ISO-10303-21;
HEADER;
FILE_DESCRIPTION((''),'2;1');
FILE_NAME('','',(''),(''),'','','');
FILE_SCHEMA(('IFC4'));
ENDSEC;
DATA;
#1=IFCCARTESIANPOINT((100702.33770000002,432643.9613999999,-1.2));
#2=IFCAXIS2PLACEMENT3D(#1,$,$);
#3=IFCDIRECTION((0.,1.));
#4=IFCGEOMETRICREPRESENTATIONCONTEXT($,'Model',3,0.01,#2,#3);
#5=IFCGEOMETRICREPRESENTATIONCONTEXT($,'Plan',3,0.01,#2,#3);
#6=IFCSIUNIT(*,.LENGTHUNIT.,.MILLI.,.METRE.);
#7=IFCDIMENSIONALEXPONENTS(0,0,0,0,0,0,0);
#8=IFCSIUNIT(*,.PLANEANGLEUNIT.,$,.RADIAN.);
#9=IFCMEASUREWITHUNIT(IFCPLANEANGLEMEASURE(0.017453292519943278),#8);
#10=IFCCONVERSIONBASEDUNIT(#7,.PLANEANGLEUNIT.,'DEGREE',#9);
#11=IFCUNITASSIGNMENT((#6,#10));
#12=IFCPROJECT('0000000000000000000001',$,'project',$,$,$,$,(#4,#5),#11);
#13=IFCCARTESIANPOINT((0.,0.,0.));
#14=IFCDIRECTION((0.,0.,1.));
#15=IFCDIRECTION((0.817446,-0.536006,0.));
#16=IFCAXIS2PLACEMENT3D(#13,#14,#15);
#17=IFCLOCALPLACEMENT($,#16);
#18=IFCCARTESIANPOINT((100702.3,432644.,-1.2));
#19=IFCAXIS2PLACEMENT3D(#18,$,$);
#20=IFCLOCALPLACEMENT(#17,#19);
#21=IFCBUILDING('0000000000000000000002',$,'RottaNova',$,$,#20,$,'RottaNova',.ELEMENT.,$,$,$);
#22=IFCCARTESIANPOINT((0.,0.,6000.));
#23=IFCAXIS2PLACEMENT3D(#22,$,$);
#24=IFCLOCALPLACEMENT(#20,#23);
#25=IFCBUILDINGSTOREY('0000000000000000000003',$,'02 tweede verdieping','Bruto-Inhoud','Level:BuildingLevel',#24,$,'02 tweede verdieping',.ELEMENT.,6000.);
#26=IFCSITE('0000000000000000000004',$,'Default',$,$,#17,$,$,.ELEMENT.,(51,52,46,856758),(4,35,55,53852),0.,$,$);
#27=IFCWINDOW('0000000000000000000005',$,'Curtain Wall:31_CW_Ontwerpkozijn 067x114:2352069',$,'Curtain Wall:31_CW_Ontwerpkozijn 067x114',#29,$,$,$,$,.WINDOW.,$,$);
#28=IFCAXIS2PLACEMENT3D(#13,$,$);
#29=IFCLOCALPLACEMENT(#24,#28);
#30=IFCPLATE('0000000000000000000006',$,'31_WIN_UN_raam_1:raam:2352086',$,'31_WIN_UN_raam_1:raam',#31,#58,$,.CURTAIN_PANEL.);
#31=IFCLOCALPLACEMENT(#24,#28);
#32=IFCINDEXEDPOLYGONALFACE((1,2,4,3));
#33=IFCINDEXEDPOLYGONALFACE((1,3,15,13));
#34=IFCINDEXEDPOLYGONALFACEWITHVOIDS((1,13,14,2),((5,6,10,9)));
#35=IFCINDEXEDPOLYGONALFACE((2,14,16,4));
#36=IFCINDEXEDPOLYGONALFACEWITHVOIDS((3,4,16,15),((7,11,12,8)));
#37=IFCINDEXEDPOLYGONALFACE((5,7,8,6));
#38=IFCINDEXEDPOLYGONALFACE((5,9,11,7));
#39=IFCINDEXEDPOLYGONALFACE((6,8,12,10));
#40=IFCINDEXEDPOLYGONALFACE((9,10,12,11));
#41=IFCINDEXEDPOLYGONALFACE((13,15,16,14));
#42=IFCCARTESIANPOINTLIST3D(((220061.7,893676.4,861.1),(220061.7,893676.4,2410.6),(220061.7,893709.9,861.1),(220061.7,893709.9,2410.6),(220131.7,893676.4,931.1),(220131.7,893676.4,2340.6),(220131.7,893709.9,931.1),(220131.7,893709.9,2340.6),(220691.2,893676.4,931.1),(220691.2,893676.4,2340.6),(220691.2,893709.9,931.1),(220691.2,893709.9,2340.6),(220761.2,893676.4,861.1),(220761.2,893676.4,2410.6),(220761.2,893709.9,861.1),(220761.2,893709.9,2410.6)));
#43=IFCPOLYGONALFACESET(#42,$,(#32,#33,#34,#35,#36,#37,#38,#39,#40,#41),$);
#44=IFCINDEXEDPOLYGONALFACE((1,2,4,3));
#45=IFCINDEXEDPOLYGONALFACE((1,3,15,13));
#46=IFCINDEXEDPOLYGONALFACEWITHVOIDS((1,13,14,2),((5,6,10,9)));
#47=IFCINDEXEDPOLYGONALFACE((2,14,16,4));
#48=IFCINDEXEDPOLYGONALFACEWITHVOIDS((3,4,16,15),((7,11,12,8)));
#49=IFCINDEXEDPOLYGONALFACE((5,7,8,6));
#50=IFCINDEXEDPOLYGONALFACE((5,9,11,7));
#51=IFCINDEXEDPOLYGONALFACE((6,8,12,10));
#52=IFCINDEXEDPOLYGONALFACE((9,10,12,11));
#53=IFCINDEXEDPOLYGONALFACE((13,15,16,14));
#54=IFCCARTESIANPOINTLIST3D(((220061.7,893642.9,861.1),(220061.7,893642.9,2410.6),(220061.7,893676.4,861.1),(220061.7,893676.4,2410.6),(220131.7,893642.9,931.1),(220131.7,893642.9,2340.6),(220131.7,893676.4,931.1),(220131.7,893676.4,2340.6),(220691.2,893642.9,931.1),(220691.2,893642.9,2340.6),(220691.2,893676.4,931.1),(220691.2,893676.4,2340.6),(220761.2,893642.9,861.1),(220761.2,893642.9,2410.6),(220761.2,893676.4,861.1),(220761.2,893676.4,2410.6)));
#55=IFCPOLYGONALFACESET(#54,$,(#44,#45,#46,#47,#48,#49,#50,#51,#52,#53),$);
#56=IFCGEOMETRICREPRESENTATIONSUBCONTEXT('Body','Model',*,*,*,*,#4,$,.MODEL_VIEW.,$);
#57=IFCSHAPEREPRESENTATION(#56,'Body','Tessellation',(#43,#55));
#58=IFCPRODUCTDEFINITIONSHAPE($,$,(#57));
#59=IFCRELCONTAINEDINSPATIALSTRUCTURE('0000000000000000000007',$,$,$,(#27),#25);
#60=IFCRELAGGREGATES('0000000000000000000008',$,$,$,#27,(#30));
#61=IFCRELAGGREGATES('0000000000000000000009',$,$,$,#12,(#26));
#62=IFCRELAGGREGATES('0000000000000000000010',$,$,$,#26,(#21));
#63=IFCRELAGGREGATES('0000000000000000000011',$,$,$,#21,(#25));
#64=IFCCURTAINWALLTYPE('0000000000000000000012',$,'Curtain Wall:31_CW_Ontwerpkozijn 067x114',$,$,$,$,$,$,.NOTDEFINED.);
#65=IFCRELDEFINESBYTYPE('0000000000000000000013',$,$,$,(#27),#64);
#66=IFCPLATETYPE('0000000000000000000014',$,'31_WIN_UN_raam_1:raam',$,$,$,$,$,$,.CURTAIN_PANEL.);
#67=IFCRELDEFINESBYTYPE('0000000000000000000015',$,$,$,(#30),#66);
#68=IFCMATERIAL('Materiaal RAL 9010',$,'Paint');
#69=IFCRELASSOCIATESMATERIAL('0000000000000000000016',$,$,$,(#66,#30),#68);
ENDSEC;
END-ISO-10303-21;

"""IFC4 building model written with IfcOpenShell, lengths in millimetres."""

from ifc_helpers import new_model, entity, si_unit, converted_unit, direction, frame, place, context, subcontext, project, spatial, indexed_curve, outline, extrude, source, transform, mapped, material, type_object, type_shapes, element, aggregate, save


model = new_model("IFC4")

# Units and contexts
model_context = context("Model", 3, precision=0.01, world=frame((100702.33770000002, 432643.9613999999, -1.2)), true_north=direction((0.0, 1.0)))
plan_context = context("Plan", 3, precision=0.01, world=frame((100702.33770000002, 432643.9613999999, -1.2)), true_north=direction((0.0, 1.0)))
body_context = subcontext(model_context, "Body", "Model", "MODEL_VIEW")
ifc_project = project(units=[si_unit("LENGTHUNIT", "METRE", prefix="MILLI"), converted_unit("PLANEANGLEUNIT", "DEGREE", entity("IfcPlaneAngleMeasure", 0.017453292519943278), si_unit("PLANEANGLEUNIT", "RADIAN"), dimensions=[0, 0, 0, 0, 0, 0, 0])], contexts=[model_context, plan_context])

# Site, building, storey
site_placement = place(None, frame((0.0, 0.0, 0.0), z_axis=(0.0, 0.0, 1.0), x_axis=(0.817446, -0.536006, 0.0)))
site = spatial("IfcSite", under=ifc_project, at=site_placement, Name="Default", CompositionType="ELEMENT", RefLatitude=(51, 52, 46, 856758), RefLongitude=(4, 35, 55, 53852), RefElevation=0.0)
building_placement = place(site_placement, frame((100702.3, 432644.0, -1.2)))
building = spatial("IfcBuilding", under=site, at=building_placement, Name="RottaNova", LongName="RottaNova", CompositionType="ELEMENT")
storey_placement = place(building_placement, frame((0.0, 0.0, 6000.0)))
storey = spatial("IfcBuildingStorey", under=building, at=storey_placement, Name="02 tweede verdieping", Description="Bruto-Inhoud", ObjectType="Level:BuildingLevel", LongName="02 tweede verdieping", CompositionType="ELEMENT", Elevation=6000.0)

# Window, plate
curtain_wall_type = type_object("IfcCurtainWallType", Name="Curtain Wall:31_CW_Ontwerpkozijn 067x114", PredefinedType="NOTDEFINED")
window_1_placement = place(storey_placement, frame((0.0, 0.0, -6000.0)))
window_1 = element("IfcWindow", 1, at=window_1_placement, inside=storey, type_object=curtain_wall_type, Name="Curtain Wall:31_CW_Ontwerpkozijn 067x114:2352069", ObjectType="Curtain Wall:31_CW_Ontwerpkozijn 067x114", PredefinedType="WINDOW")
ifc_material_1 = material(Name="Materiaal RAL 9010", Category="Paint")
plate_type_1 = type_object("IfcPlateType", Name="31_WIN_UN_raam_1:raam", PredefinedType="CURTAIN_PANEL", material=ifc_material_1)
shared_shape_1 = source(frame((100702.3, 432644.0, -1.2)), body_context, "Body", "SweptSolid", [
    extrude(outline(indexed_curve([(-349.7, -774.8), (349.7, -774.8), (349.7, 774.8), (-349.7, 774.8), (-349.7, -774.8)], self_intersect=False), holes=[indexed_curve([(-279.7, 704.8), (279.7, 704.8), (279.7, -704.8), (-279.7, -704.8), (-279.7, 704.8)], self_intersect=False)]), frame((0.0, 58.5, 774.8), z_axis=(0.0, 1.0, 0.0), x_axis=(1.0, 0.0, 0.0)), (0.0, 0.0, 1.0), 33.5),
    extrude(outline(indexed_curve([(-349.7, -774.8), (349.7, -774.8), (349.7, 774.8), (-349.7, 774.8), (-349.7, -774.8)], self_intersect=False), holes=[indexed_curve([(-279.7, 704.7), (279.7, 704.7), (279.7, -704.8), (-279.7, -704.8), (-279.7, 704.7)], self_intersect=False)]), frame((0.0, 25.0, 774.8), z_axis=(0.0, 1.0, 0.0), x_axis=(1.0, 0.0, 0.0)), (0.0, 0.0, 1.0), 33.5),
])
type_shapes(plate_type_1, [shared_shape_1])
plate_1_placement = place(window_1_placement, frame((19006.8, 28330.0, 6863.5)))
plate_1 = element("IfcPlate", 2, at=plate_1_placement, type_object=plate_type_1, material=ifc_material_1, Name="31_WIN_UN_raam_1:raam:2352086", ObjectType="31_WIN_UN_raam_1:raam", PredefinedType="CURTAIN_PANEL", context=body_context, shape_type="MappedRepresentation", body=[
    mapped(shared_shape_1, transform((100702.3, 432644.0, -1.2), scale=1.0)),
])
aggregate(window_1, [plate_1])

save(model, "model.ifc")
